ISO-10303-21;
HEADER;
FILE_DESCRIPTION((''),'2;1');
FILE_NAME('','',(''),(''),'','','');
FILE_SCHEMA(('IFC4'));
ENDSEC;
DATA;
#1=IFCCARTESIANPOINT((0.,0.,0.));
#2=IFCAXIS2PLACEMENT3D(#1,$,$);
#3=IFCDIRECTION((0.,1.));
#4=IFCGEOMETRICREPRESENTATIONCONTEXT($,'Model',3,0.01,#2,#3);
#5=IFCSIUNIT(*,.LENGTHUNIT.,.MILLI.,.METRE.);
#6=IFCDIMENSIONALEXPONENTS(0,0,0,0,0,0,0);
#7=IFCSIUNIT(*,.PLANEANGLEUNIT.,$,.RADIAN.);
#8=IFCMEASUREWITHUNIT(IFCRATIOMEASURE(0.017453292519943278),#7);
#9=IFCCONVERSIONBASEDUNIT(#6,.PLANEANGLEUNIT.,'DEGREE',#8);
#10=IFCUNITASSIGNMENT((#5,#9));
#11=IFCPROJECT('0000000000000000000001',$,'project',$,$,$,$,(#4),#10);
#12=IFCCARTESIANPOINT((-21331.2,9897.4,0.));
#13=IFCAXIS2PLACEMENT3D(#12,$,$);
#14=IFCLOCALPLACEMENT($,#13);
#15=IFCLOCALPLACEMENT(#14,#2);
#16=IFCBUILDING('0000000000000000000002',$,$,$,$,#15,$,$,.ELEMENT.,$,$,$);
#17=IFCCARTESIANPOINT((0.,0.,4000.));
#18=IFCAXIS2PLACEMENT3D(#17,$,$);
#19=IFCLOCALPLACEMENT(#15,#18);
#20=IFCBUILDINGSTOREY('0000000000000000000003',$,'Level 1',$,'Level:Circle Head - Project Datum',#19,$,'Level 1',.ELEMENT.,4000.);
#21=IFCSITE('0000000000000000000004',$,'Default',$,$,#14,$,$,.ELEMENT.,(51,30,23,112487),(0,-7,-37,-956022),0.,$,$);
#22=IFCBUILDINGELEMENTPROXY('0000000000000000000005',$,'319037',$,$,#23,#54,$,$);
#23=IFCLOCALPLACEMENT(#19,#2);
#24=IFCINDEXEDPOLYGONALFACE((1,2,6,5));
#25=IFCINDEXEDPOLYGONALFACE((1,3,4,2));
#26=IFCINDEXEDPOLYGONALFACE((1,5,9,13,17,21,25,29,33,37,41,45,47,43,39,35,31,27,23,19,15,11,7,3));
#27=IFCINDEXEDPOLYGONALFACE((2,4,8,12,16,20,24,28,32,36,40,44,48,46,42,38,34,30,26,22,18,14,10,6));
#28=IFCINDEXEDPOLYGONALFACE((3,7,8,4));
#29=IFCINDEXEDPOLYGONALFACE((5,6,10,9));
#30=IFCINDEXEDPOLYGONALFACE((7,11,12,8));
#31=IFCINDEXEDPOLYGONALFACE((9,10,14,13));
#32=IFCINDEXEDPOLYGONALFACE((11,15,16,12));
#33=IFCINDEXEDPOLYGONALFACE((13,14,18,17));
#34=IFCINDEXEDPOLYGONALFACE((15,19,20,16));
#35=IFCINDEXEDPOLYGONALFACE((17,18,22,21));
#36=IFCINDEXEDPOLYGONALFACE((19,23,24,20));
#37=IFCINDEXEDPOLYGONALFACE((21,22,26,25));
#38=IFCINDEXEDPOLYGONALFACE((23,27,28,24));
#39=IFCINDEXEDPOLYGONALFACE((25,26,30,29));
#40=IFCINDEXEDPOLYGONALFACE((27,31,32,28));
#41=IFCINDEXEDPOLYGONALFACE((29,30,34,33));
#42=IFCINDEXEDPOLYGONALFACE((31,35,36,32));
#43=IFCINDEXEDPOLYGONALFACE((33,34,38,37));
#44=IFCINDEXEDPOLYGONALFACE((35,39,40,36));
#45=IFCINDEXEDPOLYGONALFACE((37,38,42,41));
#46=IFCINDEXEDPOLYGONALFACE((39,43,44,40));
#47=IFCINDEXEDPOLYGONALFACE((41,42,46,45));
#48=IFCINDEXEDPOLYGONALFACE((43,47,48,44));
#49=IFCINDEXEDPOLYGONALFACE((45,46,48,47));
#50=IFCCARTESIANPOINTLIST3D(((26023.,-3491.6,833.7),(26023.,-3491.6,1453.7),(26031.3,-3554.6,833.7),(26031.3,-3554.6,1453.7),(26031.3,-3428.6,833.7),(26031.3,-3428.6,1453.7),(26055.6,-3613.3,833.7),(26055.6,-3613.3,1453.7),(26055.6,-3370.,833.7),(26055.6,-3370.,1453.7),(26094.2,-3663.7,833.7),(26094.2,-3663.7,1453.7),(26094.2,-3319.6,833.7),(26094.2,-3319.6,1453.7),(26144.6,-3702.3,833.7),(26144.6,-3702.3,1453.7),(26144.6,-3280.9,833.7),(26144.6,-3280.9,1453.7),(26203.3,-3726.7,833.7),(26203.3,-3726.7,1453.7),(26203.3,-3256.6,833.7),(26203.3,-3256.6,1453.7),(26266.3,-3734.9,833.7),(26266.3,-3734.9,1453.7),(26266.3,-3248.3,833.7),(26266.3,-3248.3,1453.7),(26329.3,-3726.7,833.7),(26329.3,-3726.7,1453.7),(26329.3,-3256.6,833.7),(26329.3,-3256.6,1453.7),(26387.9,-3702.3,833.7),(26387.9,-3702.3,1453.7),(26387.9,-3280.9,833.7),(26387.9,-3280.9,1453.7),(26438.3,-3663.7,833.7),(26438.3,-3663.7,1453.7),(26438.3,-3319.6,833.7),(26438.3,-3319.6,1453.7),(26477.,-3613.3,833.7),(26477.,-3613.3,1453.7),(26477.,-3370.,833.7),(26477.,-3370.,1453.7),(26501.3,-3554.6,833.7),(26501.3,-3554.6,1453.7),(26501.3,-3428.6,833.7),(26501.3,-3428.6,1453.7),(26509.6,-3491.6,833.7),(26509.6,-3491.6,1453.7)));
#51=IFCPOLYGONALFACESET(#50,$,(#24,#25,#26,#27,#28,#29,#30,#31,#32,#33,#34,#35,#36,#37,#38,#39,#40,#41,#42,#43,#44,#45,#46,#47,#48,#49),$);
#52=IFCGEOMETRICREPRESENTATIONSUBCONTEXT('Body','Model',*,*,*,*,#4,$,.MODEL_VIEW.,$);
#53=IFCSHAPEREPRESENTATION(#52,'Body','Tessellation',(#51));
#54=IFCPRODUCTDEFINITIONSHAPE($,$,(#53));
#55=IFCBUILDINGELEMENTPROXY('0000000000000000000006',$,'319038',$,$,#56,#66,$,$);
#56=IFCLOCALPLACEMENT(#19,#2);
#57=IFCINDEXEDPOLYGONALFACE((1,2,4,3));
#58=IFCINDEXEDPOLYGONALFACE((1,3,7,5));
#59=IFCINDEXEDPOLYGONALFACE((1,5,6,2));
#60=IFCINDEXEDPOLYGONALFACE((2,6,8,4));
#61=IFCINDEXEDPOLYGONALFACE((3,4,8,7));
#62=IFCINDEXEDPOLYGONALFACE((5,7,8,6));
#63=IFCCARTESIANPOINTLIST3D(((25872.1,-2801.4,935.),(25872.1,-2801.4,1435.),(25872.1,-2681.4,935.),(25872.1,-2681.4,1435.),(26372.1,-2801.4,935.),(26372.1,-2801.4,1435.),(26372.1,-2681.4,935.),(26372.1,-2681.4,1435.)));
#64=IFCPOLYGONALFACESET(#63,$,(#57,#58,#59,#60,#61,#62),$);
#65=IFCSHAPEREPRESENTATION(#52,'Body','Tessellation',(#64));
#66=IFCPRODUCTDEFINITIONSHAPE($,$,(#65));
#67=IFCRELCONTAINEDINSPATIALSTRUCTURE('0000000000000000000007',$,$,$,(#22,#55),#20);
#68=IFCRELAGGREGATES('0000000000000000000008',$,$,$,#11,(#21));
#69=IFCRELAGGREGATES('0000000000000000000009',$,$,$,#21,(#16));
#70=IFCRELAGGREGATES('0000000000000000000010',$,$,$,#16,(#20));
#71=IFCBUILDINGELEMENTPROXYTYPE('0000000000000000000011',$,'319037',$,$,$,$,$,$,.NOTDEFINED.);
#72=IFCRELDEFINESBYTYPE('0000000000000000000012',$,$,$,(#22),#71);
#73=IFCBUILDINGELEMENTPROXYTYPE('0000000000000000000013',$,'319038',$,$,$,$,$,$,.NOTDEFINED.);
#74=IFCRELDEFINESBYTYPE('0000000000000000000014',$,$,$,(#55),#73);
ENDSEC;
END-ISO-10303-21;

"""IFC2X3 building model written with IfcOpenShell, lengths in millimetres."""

from ifc_helpers import new_model, entity, si_unit, converted_unit, direction, frame, origin, origin_2d_with_axis, place, context, subcontext, project, spatial, polyline, rectangle, outline, extrude, type_object, element, save


model = new_model("IFC2X3")

# Units and contexts
model_context = context("Model", 3, precision=0.01, world=origin(), true_north=direction((0.0, 1.0)))
body_context = subcontext(model_context, "Body", "Model", "MODEL_VIEW")
ifc_project = project(units=[si_unit("LENGTHUNIT", "METRE", prefix="MILLI"), converted_unit("PLANEANGLEUNIT", "DEGREE", entity("IfcRatioMeasure", 0.017453292519943278), si_unit("PLANEANGLEUNIT", "RADIAN"), dimensions=[0, 0, 0, 0, 0, 0, 0])], contexts=[model_context])

# Site, building, storey
site_placement = place(None, frame((-21331.2, 9897.4, 0.0)))
site = spatial("IfcSite", under=ifc_project, at=site_placement, Name="Default", CompositionType="ELEMENT", RefLatitude=(51, 30, 23, 112487), RefLongitude=(0, -7, -37, -956022), RefElevation=0.0)
building_placement = place(site_placement, origin())
building = spatial("IfcBuilding", under=site, at=building_placement, CompositionType="ELEMENT")
storey_placement = place(building_placement, frame((0.0, 0.0, 4000.0)))
storey = spatial("IfcBuildingStorey", under=building, at=storey_placement, Name="Level 1", ObjectType="Level:Circle Head - Project Datum", LongName="Level 1", CompositionType="ELEMENT", Elevation=4000.0)

# Building element proxies
building_element_proxy_type_1 = type_object("IfcBuildingElementProxyType", Name="319037", PredefinedType="NOTDEFINED")
proxy_1_placement = place(storey_placement, origin())
element("IfcBuildingElementProxy", 1, at=proxy_1_placement, inside=storey, type_object=building_element_proxy_type_1, Name="319037", context=body_context, shape_type="SweptSolid", body=[
    extrude(outline(polyline([(-31.8, -241.2), (31.8, -241.2), (93.1, -224.8), (148.1, -193.0), (193.0, -148.1), (224.8, -93.1), (241.2, -31.8), (241.2, 31.8), (224.8, 93.1), (193.0, 148.1), (148.1, 193.0), (93.1, 224.8), (31.8, 241.2), (-31.8, 241.2), (-93.1, 224.8), (-148.1, 193.0), (-193.0, 148.1), (-224.8, 93.1), (-241.2, 31.8), (-241.2, -31.8), (-224.8, -93.1), (-193.0, -148.1), (-148.1, -193.0), (-93.1, -224.8), (-31.8, -241.2)])), frame((26266.3, -3491.6, 833.7), z_axis=(0.0, 0.0, 1.0), x_axis=(0.382682, 0.92388, 0.0)), (0.0, 0.0, 1.0), 620.0),
])
building_element_proxy_type_2 = type_object("IfcBuildingElementProxyType", Name="319038", PredefinedType="NOTDEFINED")
proxy_2_placement = place(storey_placement, origin())
element("IfcBuildingElementProxy", 2, at=proxy_2_placement, inside=storey, type_object=building_element_proxy_type_2, Name="319038", context=body_context, shape_type="SweptSolid", body=[
    extrude(rectangle(XDim=500.0, YDim=120.0, at=origin_2d_with_axis()), frame((26122.1, -2741.4, 935.0), z_axis=(0.0, 0.0, 1.0), x_axis=(-1.0, 0.0, 0.0)), (0.0, 0.0, 1.0), 500.0),
])

save(model, "model.ifc")
